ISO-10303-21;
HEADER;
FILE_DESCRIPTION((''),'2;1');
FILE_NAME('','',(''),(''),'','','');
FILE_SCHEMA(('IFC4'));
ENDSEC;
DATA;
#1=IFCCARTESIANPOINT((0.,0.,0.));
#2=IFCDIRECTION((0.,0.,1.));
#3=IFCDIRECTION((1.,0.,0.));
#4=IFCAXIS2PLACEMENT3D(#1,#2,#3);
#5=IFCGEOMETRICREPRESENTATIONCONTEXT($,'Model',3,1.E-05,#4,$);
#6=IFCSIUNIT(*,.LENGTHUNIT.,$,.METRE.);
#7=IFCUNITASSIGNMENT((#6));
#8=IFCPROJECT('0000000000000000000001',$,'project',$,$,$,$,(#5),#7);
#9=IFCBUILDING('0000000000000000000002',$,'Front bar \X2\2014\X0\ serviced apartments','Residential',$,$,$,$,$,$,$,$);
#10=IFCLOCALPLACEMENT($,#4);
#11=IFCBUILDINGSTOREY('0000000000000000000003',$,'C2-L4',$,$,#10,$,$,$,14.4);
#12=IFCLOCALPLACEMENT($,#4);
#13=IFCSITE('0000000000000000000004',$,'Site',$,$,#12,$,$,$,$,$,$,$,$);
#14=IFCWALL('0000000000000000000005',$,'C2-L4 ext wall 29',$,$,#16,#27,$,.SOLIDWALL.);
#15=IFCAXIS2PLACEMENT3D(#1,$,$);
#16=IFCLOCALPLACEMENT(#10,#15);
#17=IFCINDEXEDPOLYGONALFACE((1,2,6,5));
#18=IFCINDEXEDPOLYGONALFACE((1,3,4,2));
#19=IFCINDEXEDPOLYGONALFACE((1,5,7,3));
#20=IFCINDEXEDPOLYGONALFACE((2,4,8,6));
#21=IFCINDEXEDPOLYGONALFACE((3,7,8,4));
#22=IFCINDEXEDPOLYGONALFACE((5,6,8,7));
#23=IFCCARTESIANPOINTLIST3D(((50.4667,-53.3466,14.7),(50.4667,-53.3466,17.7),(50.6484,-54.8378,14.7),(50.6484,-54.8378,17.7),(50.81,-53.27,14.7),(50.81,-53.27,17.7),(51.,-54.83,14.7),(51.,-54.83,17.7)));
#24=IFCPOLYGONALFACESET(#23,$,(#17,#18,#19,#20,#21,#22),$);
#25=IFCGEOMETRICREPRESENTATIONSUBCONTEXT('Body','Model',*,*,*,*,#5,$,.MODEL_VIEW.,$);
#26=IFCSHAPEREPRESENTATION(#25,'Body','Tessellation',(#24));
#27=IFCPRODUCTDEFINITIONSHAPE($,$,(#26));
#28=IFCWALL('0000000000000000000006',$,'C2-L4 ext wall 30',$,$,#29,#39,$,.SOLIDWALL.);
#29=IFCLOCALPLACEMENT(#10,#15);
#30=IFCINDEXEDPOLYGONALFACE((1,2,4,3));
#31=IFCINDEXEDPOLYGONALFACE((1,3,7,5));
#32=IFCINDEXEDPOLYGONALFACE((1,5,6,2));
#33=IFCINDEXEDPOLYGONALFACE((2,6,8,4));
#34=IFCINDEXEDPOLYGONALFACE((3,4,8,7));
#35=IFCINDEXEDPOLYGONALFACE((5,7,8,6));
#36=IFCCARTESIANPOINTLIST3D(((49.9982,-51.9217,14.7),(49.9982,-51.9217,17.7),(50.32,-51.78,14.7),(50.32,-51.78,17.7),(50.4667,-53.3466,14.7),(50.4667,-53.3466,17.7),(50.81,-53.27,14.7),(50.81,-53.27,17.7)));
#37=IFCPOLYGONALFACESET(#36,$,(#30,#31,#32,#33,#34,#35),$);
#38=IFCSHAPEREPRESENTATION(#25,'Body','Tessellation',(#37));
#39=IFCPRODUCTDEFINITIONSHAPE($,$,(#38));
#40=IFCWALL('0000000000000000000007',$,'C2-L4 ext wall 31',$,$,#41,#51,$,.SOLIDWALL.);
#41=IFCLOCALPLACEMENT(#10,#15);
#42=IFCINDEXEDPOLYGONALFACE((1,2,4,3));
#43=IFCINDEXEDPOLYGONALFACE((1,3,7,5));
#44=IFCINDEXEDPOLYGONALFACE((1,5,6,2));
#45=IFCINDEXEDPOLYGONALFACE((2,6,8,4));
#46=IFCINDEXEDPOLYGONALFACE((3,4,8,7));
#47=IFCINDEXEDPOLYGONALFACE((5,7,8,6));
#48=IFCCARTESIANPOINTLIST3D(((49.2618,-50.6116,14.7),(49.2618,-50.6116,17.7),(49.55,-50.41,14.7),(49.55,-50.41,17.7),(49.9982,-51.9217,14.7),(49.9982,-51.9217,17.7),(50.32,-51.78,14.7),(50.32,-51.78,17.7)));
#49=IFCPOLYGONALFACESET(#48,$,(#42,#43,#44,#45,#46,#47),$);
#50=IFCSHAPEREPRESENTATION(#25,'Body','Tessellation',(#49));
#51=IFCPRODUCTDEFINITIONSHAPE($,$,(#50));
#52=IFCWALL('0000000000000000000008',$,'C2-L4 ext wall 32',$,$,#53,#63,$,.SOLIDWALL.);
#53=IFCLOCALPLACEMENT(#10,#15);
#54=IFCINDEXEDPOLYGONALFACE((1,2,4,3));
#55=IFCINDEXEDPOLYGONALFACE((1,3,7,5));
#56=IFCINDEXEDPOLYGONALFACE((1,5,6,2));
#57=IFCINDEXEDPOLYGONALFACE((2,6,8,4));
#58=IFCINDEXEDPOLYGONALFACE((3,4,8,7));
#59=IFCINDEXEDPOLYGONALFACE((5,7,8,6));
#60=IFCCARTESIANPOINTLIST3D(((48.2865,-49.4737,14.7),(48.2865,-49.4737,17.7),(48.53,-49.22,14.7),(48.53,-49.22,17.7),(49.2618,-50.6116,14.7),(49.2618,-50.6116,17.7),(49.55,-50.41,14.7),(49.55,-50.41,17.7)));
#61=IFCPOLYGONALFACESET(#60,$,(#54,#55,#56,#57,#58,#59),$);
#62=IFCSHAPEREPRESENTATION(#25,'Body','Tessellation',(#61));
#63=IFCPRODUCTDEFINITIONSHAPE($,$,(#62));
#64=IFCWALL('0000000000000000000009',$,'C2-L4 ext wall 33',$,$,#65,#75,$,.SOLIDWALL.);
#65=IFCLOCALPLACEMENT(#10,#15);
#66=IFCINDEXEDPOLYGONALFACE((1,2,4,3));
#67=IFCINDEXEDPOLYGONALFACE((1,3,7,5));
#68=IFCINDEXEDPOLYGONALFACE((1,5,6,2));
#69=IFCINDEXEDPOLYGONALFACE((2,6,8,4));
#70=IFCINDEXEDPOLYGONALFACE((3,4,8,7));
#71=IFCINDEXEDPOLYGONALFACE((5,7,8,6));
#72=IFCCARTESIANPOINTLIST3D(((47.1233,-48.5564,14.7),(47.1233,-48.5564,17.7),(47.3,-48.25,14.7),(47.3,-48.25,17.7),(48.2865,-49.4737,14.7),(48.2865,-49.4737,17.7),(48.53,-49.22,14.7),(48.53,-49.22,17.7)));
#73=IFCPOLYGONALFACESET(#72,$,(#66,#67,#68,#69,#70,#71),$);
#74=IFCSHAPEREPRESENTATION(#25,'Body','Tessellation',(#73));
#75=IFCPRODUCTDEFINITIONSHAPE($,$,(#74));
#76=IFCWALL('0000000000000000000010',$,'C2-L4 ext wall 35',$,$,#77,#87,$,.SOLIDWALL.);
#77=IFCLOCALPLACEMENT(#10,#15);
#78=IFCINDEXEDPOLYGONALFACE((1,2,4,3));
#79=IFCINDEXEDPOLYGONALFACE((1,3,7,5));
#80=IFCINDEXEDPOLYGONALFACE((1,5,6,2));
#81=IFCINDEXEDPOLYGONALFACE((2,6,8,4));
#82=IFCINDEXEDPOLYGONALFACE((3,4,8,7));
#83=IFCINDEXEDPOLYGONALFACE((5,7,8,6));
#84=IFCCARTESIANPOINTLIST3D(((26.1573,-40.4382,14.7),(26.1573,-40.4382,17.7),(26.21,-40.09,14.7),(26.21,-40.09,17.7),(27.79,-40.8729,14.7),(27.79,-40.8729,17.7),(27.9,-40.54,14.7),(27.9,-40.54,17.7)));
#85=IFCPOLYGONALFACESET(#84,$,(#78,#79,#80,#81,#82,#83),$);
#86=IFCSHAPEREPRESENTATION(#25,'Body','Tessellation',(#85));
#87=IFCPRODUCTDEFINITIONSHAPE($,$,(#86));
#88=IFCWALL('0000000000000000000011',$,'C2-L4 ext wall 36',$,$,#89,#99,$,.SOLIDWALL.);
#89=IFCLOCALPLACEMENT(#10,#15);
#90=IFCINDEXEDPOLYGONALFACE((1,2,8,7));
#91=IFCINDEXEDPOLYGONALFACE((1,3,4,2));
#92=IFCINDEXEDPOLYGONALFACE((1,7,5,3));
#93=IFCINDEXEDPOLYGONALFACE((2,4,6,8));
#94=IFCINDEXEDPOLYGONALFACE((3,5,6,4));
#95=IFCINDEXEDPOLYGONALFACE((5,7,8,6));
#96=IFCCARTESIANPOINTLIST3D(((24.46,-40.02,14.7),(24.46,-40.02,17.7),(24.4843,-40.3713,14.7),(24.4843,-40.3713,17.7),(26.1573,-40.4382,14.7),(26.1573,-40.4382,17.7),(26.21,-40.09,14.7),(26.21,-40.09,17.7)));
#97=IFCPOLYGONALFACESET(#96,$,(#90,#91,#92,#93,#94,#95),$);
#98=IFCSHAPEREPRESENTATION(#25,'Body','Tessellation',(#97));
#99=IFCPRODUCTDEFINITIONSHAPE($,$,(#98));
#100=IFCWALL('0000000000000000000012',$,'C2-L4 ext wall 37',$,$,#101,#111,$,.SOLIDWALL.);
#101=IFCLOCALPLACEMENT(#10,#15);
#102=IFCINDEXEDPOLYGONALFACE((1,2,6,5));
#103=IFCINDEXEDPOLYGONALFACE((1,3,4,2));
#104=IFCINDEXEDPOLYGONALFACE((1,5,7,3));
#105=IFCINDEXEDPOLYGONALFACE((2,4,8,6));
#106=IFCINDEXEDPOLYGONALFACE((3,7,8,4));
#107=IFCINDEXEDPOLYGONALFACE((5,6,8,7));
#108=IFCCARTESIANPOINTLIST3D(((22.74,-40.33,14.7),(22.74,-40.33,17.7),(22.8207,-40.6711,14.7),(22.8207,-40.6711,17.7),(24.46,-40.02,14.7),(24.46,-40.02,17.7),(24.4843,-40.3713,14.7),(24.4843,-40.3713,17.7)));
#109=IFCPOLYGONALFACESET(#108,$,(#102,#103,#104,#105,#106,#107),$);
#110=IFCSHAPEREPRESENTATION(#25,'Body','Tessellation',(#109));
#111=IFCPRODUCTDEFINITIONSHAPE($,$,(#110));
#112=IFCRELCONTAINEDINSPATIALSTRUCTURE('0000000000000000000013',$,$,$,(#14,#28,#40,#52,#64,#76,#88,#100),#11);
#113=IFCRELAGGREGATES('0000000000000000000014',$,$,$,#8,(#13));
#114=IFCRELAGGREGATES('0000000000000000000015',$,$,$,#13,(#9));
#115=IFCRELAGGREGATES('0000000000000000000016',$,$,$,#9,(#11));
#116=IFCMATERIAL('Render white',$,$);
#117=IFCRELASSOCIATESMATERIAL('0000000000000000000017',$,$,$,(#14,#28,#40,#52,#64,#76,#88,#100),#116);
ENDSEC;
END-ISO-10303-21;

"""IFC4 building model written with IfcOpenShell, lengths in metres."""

from ifc_helpers import new_model, si_unit, frame, origin_with_axes, place, context, subcontext, project, spatial, polyline, outline, extrude, material, element, save


model = new_model("IFC4")

# Units and contexts
model_context = context("Model", 3, precision=1e-05, world=origin_with_axes())
body_context = subcontext(model_context, "Body", "Model", "MODEL_VIEW")
ifc_project = project(units=[si_unit("LENGTHUNIT", "METRE")], contexts=[model_context])

# Site, building, storey
site_placement = place(None, origin_with_axes())
site = spatial("IfcSite", under=ifc_project, at=site_placement, Name="Site")
building = spatial("IfcBuilding", under=site, Name="Front bar — serviced apartments", Description="Residential")
storey_placement = place(None, origin_with_axes())
storey = spatial("IfcBuildingStorey", under=building, at=storey_placement, Name="C2-L4", Elevation=14.4)

# Walls
ifc_material_1 = material(Name="Render white")
wall_1_placement = place(storey_placement, origin_with_axes())
element("IfcWall", 1, at=wall_1_placement, inside=storey, material=ifc_material_1, Name="C2-L4 ext wall 29", PredefinedType="SOLIDWALL", context=body_context, shape_type="SweptSolid", body=[
    extrude(outline(polyline([(51.0, -54.83), (50.81, -53.27), (50.4667, -53.3466), (50.6484, -54.8378), (51.0, -54.83)])), frame((0.0, 0.0, 14.7), z_axis=(0.0, 0.0, 1.0), x_axis=(1.0, 0.0, 0.0)), (0.0, 0.0, 1.0), 3.0),
])
wall_2_placement = place(storey_placement, origin_with_axes())
element("IfcWall", 2, at=wall_2_placement, inside=storey, material=ifc_material_1, Name="C2-L4 ext wall 30", PredefinedType="SOLIDWALL", context=body_context, shape_type="SweptSolid", body=[
    extrude(outline(polyline([(50.81, -53.27), (50.32, -51.78), (49.9982, -51.9217), (50.4667, -53.3466), (50.81, -53.27)])), frame((0.0, 0.0, 14.7), z_axis=(0.0, 0.0, 1.0), x_axis=(1.0, 0.0, 0.0)), (0.0, 0.0, 1.0), 3.0),
])
wall_3_placement = place(storey_placement, origin_with_axes())
element("IfcWall", 3, at=wall_3_placement, inside=storey, material=ifc_material_1, Name="C2-L4 ext wall 31", PredefinedType="SOLIDWALL", context=body_context, shape_type="SweptSolid", body=[
    extrude(outline(polyline([(50.32, -51.78), (49.55, -50.41), (49.2618, -50.6116), (49.9982, -51.9217), (50.32, -51.78)])), frame((0.0, 0.0, 14.7), z_axis=(0.0, 0.0, 1.0), x_axis=(1.0, 0.0, 0.0)), (0.0, 0.0, 1.0), 3.0),
])
wall_4_placement = place(storey_placement, origin_with_axes())
element("IfcWall", 4, at=wall_4_placement, inside=storey, material=ifc_material_1, Name="C2-L4 ext wall 32", PredefinedType="SOLIDWALL", context=body_context, shape_type="SweptSolid", body=[
    extrude(outline(polyline([(49.55, -50.41), (48.53, -49.22), (48.2865, -49.4737), (49.2618, -50.6116), (49.55, -50.41)])), frame((0.0, 0.0, 14.7), z_axis=(0.0, 0.0, 1.0), x_axis=(1.0, 0.0, 0.0)), (0.0, 0.0, 1.0), 3.0),
])
wall_5_placement = place(storey_placement, origin_with_axes())
element("IfcWall", 5, at=wall_5_placement, inside=storey, material=ifc_material_1, Name="C2-L4 ext wall 33", PredefinedType="SOLIDWALL", context=body_context, shape_type="SweptSolid", body=[
    extrude(outline(polyline([(48.53, -49.22), (47.3, -48.25), (47.1233, -48.5564), (48.2865, -49.4737), (48.53, -49.22)])), frame((0.0, 0.0, 14.7), z_axis=(0.0, 0.0, 1.0), x_axis=(1.0, 0.0, 0.0)), (0.0, 0.0, 1.0), 3.0),
])

# Walls
wall_6_placement = place(storey_placement, origin_with_axes())
element("IfcWall", 6, at=wall_6_placement, inside=storey, material=ifc_material_1, Name="C2-L4 ext wall 35", PredefinedType="SOLIDWALL", context=body_context, shape_type="SweptSolid", body=[
    extrude(outline(polyline([(27.9, -40.54), (26.21, -40.09), (26.1573, -40.4382), (27.79, -40.8729), (27.9, -40.54)])), frame((0.0, 0.0, 14.7), z_axis=(0.0, 0.0, 1.0), x_axis=(1.0, 0.0, 0.0)), (0.0, 0.0, 1.0), 3.0),
])
wall_7_placement = place(storey_placement, origin_with_axes())
element("IfcWall", 7, at=wall_7_placement, inside=storey, material=ifc_material_1, Name="C2-L4 ext wall 36", PredefinedType="SOLIDWALL", context=body_context, shape_type="SweptSolid", body=[
    extrude(outline(polyline([(26.21, -40.09), (24.46, -40.02), (24.4843, -40.3713), (26.1573, -40.4382), (26.21, -40.09)])), frame((0.0, 0.0, 14.7), z_axis=(0.0, 0.0, 1.0), x_axis=(1.0, 0.0, 0.0)), (0.0, 0.0, 1.0), 3.0),
])
wall_8_placement = place(storey_placement, origin_with_axes())
element("IfcWall", 8, at=wall_8_placement, inside=storey, material=ifc_material_1, Name="C2-L4 ext wall 37", PredefinedType="SOLIDWALL", context=body_context, shape_type="SweptSolid", body=[
    extrude(outline(polyline([(24.46, -40.02), (22.74, -40.33), (22.8207, -40.6711), (24.4843, -40.3713), (24.46, -40.02)])), frame((0.0, 0.0, 14.7), z_axis=(0.0, 0.0, 1.0), x_axis=(1.0, 0.0, 0.0)), (0.0, 0.0, 1.0), 3.0),
])

save(model, "model.ifc")
